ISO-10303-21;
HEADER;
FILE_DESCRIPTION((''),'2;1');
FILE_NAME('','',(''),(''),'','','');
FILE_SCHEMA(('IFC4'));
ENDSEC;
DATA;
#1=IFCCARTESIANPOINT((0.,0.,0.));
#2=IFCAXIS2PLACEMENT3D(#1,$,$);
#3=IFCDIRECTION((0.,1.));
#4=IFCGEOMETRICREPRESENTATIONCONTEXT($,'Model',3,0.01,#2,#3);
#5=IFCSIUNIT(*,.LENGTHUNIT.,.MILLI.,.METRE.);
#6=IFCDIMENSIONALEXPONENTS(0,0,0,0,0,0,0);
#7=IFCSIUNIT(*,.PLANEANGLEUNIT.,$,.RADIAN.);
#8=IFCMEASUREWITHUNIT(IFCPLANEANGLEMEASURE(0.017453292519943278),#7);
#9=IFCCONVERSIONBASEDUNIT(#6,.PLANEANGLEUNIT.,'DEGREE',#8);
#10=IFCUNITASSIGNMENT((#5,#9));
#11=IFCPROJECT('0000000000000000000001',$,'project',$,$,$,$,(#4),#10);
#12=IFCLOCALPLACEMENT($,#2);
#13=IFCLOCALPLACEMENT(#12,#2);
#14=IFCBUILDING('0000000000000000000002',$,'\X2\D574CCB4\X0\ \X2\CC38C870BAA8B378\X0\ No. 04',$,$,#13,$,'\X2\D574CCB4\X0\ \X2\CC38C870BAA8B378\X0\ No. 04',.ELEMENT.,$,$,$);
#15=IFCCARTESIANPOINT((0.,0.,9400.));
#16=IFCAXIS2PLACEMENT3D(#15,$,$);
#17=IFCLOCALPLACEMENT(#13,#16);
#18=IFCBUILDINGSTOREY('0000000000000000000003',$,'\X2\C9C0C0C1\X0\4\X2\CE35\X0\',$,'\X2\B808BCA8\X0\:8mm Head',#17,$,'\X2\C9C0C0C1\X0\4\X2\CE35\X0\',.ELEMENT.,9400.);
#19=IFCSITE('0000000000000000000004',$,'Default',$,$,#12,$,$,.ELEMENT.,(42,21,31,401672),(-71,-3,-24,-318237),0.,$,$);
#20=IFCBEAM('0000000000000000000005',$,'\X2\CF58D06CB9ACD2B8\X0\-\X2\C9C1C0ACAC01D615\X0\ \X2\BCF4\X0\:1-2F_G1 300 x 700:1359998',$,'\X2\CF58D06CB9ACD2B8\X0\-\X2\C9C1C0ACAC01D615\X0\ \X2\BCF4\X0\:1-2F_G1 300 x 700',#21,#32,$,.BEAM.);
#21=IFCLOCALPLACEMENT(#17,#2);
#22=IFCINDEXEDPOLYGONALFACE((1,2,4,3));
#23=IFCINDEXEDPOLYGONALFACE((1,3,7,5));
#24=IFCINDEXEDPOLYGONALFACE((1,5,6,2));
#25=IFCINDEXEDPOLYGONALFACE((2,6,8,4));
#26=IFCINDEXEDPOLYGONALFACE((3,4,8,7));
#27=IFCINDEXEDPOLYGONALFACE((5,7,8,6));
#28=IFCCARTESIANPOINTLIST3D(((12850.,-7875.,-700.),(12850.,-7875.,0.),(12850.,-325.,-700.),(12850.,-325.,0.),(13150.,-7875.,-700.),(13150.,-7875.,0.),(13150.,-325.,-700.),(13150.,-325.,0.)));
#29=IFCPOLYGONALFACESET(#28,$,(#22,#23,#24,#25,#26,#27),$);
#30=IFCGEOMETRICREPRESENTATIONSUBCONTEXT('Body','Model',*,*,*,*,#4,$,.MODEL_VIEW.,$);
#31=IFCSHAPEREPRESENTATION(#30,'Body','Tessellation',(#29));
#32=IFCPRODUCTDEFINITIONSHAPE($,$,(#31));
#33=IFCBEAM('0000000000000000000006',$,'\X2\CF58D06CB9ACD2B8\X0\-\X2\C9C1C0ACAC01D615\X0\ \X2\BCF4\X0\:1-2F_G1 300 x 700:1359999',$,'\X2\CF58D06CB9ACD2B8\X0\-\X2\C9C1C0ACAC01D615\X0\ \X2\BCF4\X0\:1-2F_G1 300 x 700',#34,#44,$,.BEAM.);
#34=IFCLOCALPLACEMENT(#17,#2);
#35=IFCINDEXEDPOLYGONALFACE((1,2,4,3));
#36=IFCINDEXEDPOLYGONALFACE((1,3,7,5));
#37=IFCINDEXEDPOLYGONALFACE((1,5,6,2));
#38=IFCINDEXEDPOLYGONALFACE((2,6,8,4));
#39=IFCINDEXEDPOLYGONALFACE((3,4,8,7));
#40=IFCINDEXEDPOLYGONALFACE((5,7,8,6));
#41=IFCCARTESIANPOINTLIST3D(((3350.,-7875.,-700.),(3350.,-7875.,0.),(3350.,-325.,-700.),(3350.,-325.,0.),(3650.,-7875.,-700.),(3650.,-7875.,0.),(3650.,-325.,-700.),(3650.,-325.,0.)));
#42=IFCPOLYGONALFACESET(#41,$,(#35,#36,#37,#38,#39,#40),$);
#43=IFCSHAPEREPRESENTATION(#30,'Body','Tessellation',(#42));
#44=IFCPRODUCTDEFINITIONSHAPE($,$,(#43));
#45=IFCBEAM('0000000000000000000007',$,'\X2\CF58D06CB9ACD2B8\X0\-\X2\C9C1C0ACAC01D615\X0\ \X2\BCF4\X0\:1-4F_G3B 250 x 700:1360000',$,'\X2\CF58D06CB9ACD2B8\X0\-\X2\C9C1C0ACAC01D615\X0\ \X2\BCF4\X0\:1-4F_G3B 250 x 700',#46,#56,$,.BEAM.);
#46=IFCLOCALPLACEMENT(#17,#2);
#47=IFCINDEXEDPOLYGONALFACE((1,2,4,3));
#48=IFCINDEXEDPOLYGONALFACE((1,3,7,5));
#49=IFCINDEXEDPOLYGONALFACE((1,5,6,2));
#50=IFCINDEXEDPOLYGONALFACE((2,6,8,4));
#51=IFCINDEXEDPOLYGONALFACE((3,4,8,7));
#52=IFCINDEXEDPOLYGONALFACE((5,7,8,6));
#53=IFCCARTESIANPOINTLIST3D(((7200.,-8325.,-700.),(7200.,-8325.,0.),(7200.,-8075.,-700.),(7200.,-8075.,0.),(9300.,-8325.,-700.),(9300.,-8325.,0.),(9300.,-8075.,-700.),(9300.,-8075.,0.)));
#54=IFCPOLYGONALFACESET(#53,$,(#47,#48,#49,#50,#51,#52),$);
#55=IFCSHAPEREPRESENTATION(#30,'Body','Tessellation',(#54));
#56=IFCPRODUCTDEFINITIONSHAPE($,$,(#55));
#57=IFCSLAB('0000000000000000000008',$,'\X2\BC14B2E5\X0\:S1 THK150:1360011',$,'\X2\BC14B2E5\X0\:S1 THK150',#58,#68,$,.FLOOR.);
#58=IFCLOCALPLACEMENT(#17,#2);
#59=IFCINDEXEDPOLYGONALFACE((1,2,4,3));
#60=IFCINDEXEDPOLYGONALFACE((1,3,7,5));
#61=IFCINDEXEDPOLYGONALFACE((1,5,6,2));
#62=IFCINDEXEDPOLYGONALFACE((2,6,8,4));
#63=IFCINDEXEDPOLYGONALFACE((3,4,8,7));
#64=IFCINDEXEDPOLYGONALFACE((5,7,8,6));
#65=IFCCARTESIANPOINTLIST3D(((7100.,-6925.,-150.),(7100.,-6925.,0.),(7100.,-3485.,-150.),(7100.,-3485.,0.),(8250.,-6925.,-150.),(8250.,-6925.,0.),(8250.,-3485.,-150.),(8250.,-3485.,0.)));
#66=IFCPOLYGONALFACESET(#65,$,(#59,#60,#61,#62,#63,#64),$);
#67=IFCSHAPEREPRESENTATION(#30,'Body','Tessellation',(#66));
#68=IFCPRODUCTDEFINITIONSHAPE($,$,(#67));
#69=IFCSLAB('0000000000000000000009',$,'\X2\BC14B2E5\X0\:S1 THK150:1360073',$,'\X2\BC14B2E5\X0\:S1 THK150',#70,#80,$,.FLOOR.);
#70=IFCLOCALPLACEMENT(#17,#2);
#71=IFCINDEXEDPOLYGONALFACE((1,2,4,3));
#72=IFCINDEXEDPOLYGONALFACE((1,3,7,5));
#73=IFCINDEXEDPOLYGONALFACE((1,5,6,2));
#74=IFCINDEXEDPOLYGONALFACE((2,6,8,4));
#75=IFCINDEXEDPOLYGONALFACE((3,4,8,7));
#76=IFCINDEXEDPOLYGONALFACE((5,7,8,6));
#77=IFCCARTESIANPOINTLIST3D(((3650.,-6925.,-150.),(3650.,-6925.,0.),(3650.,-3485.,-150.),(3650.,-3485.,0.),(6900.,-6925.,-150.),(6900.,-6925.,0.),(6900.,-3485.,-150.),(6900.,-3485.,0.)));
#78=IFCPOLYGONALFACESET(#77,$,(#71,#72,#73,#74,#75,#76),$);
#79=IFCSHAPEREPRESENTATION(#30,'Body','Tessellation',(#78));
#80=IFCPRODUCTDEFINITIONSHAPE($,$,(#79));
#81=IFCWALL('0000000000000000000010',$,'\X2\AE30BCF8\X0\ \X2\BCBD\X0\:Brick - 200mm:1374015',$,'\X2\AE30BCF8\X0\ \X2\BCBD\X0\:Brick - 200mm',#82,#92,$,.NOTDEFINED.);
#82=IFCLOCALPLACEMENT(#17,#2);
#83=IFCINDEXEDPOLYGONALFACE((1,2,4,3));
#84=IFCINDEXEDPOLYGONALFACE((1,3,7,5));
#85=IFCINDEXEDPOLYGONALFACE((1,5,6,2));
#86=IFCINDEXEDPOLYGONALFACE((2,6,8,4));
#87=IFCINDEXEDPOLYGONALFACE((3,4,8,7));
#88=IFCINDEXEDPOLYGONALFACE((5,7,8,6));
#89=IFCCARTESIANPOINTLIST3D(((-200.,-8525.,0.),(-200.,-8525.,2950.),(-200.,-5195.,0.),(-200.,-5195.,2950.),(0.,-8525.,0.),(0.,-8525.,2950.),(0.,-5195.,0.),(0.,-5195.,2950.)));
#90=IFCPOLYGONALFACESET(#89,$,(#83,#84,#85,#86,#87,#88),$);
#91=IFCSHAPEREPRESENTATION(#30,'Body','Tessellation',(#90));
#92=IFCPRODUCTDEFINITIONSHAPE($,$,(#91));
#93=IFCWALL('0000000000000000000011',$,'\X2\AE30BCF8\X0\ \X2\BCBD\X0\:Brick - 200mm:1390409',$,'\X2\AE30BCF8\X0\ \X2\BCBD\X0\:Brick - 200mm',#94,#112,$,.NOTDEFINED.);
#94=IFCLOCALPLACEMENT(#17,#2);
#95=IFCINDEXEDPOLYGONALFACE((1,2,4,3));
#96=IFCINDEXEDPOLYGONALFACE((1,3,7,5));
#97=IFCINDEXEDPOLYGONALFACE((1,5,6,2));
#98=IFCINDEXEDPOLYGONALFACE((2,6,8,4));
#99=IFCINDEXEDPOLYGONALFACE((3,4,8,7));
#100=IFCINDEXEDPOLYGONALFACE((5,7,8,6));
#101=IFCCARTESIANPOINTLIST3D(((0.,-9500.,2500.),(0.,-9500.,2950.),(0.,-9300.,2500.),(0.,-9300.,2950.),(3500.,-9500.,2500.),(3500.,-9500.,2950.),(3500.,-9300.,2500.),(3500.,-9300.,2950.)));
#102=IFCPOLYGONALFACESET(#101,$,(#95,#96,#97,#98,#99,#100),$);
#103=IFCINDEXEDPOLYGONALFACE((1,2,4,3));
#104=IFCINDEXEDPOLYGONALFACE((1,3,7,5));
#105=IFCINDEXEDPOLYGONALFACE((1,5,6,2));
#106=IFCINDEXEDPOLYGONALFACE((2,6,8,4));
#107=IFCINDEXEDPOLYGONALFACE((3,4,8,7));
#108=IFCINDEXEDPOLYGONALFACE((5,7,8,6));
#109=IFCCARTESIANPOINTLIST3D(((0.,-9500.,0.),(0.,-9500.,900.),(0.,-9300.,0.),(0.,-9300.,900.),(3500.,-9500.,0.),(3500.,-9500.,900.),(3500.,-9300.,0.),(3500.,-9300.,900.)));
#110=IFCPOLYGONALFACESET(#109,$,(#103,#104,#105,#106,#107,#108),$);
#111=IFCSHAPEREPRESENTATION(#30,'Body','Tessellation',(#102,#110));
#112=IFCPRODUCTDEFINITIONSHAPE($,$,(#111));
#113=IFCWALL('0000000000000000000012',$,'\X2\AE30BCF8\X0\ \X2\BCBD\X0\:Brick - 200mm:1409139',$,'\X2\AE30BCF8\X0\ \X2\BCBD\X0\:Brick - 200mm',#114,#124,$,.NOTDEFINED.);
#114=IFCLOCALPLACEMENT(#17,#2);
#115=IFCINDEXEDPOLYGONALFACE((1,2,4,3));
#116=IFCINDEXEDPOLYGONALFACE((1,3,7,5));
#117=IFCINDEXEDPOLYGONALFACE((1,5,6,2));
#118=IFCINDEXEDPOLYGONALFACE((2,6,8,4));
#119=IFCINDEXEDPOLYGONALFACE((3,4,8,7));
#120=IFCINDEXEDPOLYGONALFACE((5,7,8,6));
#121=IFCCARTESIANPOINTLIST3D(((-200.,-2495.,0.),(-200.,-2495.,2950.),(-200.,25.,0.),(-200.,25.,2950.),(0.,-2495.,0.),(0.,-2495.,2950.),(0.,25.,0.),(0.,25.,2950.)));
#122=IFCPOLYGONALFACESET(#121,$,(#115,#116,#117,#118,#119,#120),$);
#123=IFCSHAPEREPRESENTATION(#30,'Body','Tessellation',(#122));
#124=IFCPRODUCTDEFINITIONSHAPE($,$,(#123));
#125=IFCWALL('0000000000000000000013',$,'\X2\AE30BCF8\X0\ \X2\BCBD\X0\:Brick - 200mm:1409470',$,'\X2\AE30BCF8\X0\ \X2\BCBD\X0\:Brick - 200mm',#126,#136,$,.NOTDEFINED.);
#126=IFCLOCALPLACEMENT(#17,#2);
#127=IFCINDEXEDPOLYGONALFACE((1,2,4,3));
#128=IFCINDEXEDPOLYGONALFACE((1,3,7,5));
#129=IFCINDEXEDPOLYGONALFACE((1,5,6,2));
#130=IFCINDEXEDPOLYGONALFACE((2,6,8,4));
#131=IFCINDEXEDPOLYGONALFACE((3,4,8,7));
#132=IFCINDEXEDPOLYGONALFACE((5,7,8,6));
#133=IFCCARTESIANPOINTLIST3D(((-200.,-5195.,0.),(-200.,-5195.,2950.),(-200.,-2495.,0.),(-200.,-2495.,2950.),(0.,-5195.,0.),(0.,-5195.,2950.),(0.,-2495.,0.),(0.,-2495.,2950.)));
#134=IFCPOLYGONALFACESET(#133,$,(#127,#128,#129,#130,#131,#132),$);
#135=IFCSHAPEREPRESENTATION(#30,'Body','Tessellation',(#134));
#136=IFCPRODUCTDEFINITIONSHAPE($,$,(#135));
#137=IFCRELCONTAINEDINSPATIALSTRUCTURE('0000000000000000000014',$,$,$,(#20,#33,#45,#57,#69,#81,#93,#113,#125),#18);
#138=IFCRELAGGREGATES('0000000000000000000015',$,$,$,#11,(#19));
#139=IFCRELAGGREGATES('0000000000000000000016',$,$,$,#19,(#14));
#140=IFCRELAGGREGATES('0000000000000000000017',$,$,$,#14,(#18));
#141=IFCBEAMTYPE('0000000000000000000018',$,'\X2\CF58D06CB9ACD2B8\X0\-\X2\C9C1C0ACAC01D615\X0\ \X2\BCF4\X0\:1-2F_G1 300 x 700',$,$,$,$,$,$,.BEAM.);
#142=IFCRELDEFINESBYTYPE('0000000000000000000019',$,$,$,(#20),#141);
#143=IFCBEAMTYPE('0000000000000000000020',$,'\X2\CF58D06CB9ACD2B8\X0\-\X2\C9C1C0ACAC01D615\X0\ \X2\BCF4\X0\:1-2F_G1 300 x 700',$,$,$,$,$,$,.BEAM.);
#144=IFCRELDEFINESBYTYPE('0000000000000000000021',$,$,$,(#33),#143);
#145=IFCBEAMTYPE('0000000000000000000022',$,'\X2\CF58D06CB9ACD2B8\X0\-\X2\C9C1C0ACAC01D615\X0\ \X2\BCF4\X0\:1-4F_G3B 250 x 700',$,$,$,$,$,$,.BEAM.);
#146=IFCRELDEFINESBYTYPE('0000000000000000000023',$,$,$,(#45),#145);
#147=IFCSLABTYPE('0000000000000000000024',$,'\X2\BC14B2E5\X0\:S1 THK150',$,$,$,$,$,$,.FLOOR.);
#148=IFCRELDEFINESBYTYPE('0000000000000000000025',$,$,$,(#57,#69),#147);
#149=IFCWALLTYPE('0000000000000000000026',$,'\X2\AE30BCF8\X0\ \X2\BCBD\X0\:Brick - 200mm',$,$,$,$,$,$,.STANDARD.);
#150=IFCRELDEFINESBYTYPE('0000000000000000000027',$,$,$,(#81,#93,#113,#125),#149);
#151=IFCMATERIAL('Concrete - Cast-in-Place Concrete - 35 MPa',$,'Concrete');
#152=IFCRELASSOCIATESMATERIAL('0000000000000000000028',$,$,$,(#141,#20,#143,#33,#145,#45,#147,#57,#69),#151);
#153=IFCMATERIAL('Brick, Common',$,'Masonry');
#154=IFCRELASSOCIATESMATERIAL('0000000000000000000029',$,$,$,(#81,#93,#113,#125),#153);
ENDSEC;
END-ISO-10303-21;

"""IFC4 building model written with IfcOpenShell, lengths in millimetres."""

from ifc_helpers import new_model, entity, si_unit, converted_unit, direction, frame, origin, place, context, subcontext, project, spatial, indexed_curve, outline, extrude, source, transform, mapped, material, type_object, type_shapes, element, save


model = new_model("IFC4")

# Units and contexts
model_context = context("Model", 3, precision=0.01, world=origin(), true_north=direction((0.0, 1.0)))
body_context = subcontext(model_context, "Body", "Model", "MODEL_VIEW")
ifc_project = project(units=[si_unit("LENGTHUNIT", "METRE", prefix="MILLI"), converted_unit("PLANEANGLEUNIT", "DEGREE", entity("IfcPlaneAngleMeasure", 0.017453292519943278), si_unit("PLANEANGLEUNIT", "RADIAN"), dimensions=[0, 0, 0, 0, 0, 0, 0])], contexts=[model_context])

# Site, building, storey
site_placement = place(None, origin())
site = spatial("IfcSite", under=ifc_project, at=site_placement, Name="Default", CompositionType="ELEMENT", RefLatitude=(42, 21, 31, 401672), RefLongitude=(-71, -3, -24, -318237), RefElevation=0.0)
building_placement = place(site_placement, origin())
building = spatial("IfcBuilding", under=site, at=building_placement, Name="해체 참조모델 No. 04", LongName="해체 참조모델 No. 04", CompositionType="ELEMENT")
storey_placement = place(building_placement, frame((0.0, 0.0, 9400.0)))
storey = spatial("IfcBuildingStorey", under=building, at=storey_placement, Name="지상4층", ObjectType="레벨:8mm Head", LongName="지상4층", CompositionType="ELEMENT", Elevation=9400.0)

# Beams
ifc_material_1 = material(Name="Concrete - Cast-in-Place Concrete - 35 MPa", Category="Concrete")
beam_type_1 = type_object("IfcBeamType", Name="콘크리트-직사각형 보:1-2F_G1 300 x 700", PredefinedType="BEAM", material=ifc_material_1)
shared_shape_1 = source(origin(), body_context, "Body", "SweptSolid", [
    extrude(outline(indexed_curve([(-150.0, -350.0), (150.0, -350.0), (150.0, 350.0), (-150.0, 350.0), (-150.0, -350.0)], self_intersect=False)), frame((13000.0, -325.0, 9050.0), z_axis=(0.0, -1.0, 0.0), x_axis=(-1.0, 0.0, 0.0)), (0.0, 0.0, 1.0), 7550.0),
])
type_shapes(beam_type_1, [shared_shape_1])
beam_1_placement = place(storey_placement, frame((0.0, 0.0, -9400.0)))
element("IfcBeam", 1, at=beam_1_placement, inside=storey, type_object=beam_type_1, material=ifc_material_1, Name="콘크리트-직사각형 보:1-2F_G1 300 x 700:1359998", ObjectType="콘크리트-직사각형 보:1-2F_G1 300 x 700", PredefinedType="BEAM", context=body_context, shape_type="MappedRepresentation", body=[
    mapped(shared_shape_1, transform((0.0, 0.0, 0.0), scale=1.0)),
])
beam_type_2 = type_object("IfcBeamType", Name="콘크리트-직사각형 보:1-2F_G1 300 x 700", PredefinedType="BEAM", material=ifc_material_1)
shared_shape_2 = source(origin(), body_context, "Body", "SweptSolid", [
    extrude(outline(indexed_curve([(-150.0, -350.0), (150.0, -350.0), (150.0, 350.0), (-150.0, 350.0), (-150.0, -350.0)], self_intersect=False)), frame((3500.0, -325.0, 9050.0), z_axis=(0.0, -1.0, 0.0), x_axis=(-1.0, 0.0, 0.0)), (0.0, 0.0, 1.0), 7550.0),
])
type_shapes(beam_type_2, [shared_shape_2])
beam_2_placement = place(storey_placement, frame((0.0, 0.0, -9400.0)))
element("IfcBeam", 2, at=beam_2_placement, inside=storey, type_object=beam_type_2, material=ifc_material_1, Name="콘크리트-직사각형 보:1-2F_G1 300 x 700:1359999", ObjectType="콘크리트-직사각형 보:1-2F_G1 300 x 700", PredefinedType="BEAM", context=body_context, shape_type="MappedRepresentation", body=[
    mapped(shared_shape_2, transform((0.0, 0.0, 0.0), scale=1.0)),
])
beam_type_3 = type_object("IfcBeamType", Name="콘크리트-직사각형 보:1-4F_G3B 250 x 700", PredefinedType="BEAM", material=ifc_material_1)
shared_shape_3 = source(origin(), body_context, "Body", "SweptSolid", [
    extrude(outline(indexed_curve([(-350.0, -125.0), (350.0, -125.0), (350.0, 125.0), (-350.0, 125.0), (-350.0, -125.0)], self_intersect=False)), frame((7200.0, -8200.0, 9050.0), z_axis=(1.0, 0.0, 0.0), x_axis=(0.0, 0.0, -1.0)), (0.0, 0.0, 1.0), 2100.0),
])
type_shapes(beam_type_3, [shared_shape_3])
beam_3_placement = place(storey_placement, frame((0.0, 0.0, -9400.0)))
element("IfcBeam", 3, at=beam_3_placement, inside=storey, type_object=beam_type_3, material=ifc_material_1, Name="콘크리트-직사각형 보:1-4F_G3B 250 x 700:1360000", ObjectType="콘크리트-직사각형 보:1-4F_G3B 250 x 700", PredefinedType="BEAM", context=body_context, shape_type="MappedRepresentation", body=[
    mapped(shared_shape_3, transform((0.0, 0.0, 0.0), scale=1.0)),
])

# Slabs
slab_type_1 = type_object("IfcSlabType", Name="바닥:S1 THK150", PredefinedType="FLOOR", material=ifc_material_1)
slab_1_placement = place(storey_placement, origin())
element("IfcSlab", 4, at=slab_1_placement, inside=storey, type_object=slab_type_1, material=ifc_material_1, Name="바닥:S1 THK150:1360011", ObjectType="바닥:S1 THK150", PredefinedType="FLOOR", context=body_context, shape_type="SweptSolid", body=[
    extrude(outline(indexed_curve([(-1720.0, -575.0), (1720.0, -575.0), (1720.0, 575.0), (-1720.0, 575.0), (-1720.0, -575.0)], self_intersect=False)), frame((7675.0, -5205.0, 0.0), z_axis=(0.0, 0.0, -1.0), x_axis=(0.0, 1.0, 0.0)), (0.0, 0.0, 1.0), 150.0),
])
slab_2_placement = place(storey_placement, origin())
element("IfcSlab", 5, at=slab_2_placement, inside=storey, type_object=slab_type_1, material=ifc_material_1, Name="바닥:S1 THK150:1360073", ObjectType="바닥:S1 THK150", PredefinedType="FLOOR", context=body_context, shape_type="SweptSolid", body=[
    extrude(outline(indexed_curve([(-1720.0, -1625.0), (1720.0, -1625.0), (1720.0, 1625.0), (-1720.0, 1625.0), (-1720.0, -1625.0)], self_intersect=False)), frame((5275.0, -5205.0, 0.0), z_axis=(0.0, 0.0, -1.0), x_axis=(0.0, 1.0, 0.0)), (0.0, 0.0, 1.0), 150.0),
])

# Wall
ifc_material_2 = material(Name="Brick, Common", Category="Masonry")
wall_type = type_object("IfcWallType", Name="기본 벽:Brick - 200mm", PredefinedType="STANDARD")
wall_1_placement = place(storey_placement, frame((-100.0, -8525.0, 0.0), z_axis=(0.0, 0.0, 1.0), x_axis=(0.0, 1.0, 0.0)))
element("IfcWall", 6, at=wall_1_placement, inside=storey, type_object=wall_type, material=ifc_material_2, Name="기본 벽:Brick - 200mm:1374015", ObjectType="기본 벽:Brick - 200mm", PredefinedType="NOTDEFINED", context=body_context, shape_type="SweptSolid", body=[
    extrude(outline(indexed_curve([(3330.0, 100.0), (0.0, 100.0), (0.0, -100.0), (3330.0, -100.0), (3330.0, 100.0)], self_intersect=False)), origin(), (0.0, 0.0, 1.0), 2950.0),
])

# Wall, opening
wall_2_placement = place(storey_placement, frame((0.0, -9400.0, 0.0)))
wall_2 = element("IfcWall", 7, at=wall_2_placement, inside=storey, type_object=wall_type, material=ifc_material_2, Name="기본 벽:Brick - 200mm:1390409", ObjectType="기본 벽:Brick - 200mm", PredefinedType="NOTDEFINED", context=body_context, shape_type="SweptSolid", body=[
    extrude(outline(indexed_curve([(-100.0, -1750.0), (100.0, -1750.0), (100.0, 1750.0), (-100.0, 1750.0), (-100.0, -1750.0)], self_intersect=False)), frame((1750.0, 0.0, 2500.0), z_axis=(0.0, 0.0, 1.0), x_axis=(0.0, 1.0, 0.0)), (0.0, 0.0, 1.0), 450.0),
    extrude(outline(indexed_curve([(-100.0, -1750.0), (100.0, -1750.0), (100.0, 1750.0), (-100.0, 1750.0), (-100.0, -1750.0)], self_intersect=False)), frame((1750.0, 0.0, 0.0), z_axis=(0.0, 0.0, 1.0), x_axis=(0.0, 1.0, 0.0)), (0.0, 0.0, 1.0), 900.0),
])
opening_placement = place(wall_2_placement, origin())
element("IfcOpeningElement", 8, at=opening_placement, cuts=wall_2, PredefinedType="OPENING", context=body_context, shape_type="SweptSolid", body=[
    extrude(outline(indexed_curve([(-800.0, -8250.0), (800.0, -8250.0), (800.0, 8250.0), (-800.0, 8250.0), (-800.0, -8250.0)], self_intersect=False)), frame((8250.0, -252.4, 1700.0), z_axis=(0.0, 1.0, 0.0), x_axis=(0.0, 0.0, 1.0)), (0.0, 0.0, 1.0), 504.8),
])

# Walls
wall_3_placement = place(storey_placement, frame((-100.0, -2495.0, 0.0), z_axis=(0.0, 0.0, 1.0), x_axis=(0.0, 1.0, 0.0)))
element("IfcWall", 9, at=wall_3_placement, inside=storey, type_object=wall_type, material=ifc_material_2, Name="기본 벽:Brick - 200mm:1409139", ObjectType="기본 벽:Brick - 200mm", PredefinedType="NOTDEFINED", context=body_context, shape_type="SweptSolid", body=[
    extrude(outline(indexed_curve([(2520.0, 100.0), (0.0, 100.0), (0.0, -100.0), (2520.0, -100.0), (2520.0, 100.0)], self_intersect=False)), origin(), (0.0, 0.0, 1.0), 2950.0),
])
wall_4_placement = place(storey_placement, frame((-100.0, -5195.0, 0.0), z_axis=(0.0, 0.0, 1.0), x_axis=(0.0, 1.0, 0.0)))
element("IfcWall", 10, at=wall_4_placement, inside=storey, type_object=wall_type, material=ifc_material_2, Name="기본 벽:Brick - 200mm:1409470", ObjectType="기본 벽:Brick - 200mm", PredefinedType="NOTDEFINED", context=body_context, shape_type="SweptSolid", body=[
    extrude(outline(indexed_curve([(2700.0, 100.0), (0.0, 100.0), (0.0, -100.0), (2700.0, -100.0), (2700.0, 100.0)], self_intersect=False)), origin(), (0.0, 0.0, 1.0), 2950.0),
])

save(model, "model.ifc")
